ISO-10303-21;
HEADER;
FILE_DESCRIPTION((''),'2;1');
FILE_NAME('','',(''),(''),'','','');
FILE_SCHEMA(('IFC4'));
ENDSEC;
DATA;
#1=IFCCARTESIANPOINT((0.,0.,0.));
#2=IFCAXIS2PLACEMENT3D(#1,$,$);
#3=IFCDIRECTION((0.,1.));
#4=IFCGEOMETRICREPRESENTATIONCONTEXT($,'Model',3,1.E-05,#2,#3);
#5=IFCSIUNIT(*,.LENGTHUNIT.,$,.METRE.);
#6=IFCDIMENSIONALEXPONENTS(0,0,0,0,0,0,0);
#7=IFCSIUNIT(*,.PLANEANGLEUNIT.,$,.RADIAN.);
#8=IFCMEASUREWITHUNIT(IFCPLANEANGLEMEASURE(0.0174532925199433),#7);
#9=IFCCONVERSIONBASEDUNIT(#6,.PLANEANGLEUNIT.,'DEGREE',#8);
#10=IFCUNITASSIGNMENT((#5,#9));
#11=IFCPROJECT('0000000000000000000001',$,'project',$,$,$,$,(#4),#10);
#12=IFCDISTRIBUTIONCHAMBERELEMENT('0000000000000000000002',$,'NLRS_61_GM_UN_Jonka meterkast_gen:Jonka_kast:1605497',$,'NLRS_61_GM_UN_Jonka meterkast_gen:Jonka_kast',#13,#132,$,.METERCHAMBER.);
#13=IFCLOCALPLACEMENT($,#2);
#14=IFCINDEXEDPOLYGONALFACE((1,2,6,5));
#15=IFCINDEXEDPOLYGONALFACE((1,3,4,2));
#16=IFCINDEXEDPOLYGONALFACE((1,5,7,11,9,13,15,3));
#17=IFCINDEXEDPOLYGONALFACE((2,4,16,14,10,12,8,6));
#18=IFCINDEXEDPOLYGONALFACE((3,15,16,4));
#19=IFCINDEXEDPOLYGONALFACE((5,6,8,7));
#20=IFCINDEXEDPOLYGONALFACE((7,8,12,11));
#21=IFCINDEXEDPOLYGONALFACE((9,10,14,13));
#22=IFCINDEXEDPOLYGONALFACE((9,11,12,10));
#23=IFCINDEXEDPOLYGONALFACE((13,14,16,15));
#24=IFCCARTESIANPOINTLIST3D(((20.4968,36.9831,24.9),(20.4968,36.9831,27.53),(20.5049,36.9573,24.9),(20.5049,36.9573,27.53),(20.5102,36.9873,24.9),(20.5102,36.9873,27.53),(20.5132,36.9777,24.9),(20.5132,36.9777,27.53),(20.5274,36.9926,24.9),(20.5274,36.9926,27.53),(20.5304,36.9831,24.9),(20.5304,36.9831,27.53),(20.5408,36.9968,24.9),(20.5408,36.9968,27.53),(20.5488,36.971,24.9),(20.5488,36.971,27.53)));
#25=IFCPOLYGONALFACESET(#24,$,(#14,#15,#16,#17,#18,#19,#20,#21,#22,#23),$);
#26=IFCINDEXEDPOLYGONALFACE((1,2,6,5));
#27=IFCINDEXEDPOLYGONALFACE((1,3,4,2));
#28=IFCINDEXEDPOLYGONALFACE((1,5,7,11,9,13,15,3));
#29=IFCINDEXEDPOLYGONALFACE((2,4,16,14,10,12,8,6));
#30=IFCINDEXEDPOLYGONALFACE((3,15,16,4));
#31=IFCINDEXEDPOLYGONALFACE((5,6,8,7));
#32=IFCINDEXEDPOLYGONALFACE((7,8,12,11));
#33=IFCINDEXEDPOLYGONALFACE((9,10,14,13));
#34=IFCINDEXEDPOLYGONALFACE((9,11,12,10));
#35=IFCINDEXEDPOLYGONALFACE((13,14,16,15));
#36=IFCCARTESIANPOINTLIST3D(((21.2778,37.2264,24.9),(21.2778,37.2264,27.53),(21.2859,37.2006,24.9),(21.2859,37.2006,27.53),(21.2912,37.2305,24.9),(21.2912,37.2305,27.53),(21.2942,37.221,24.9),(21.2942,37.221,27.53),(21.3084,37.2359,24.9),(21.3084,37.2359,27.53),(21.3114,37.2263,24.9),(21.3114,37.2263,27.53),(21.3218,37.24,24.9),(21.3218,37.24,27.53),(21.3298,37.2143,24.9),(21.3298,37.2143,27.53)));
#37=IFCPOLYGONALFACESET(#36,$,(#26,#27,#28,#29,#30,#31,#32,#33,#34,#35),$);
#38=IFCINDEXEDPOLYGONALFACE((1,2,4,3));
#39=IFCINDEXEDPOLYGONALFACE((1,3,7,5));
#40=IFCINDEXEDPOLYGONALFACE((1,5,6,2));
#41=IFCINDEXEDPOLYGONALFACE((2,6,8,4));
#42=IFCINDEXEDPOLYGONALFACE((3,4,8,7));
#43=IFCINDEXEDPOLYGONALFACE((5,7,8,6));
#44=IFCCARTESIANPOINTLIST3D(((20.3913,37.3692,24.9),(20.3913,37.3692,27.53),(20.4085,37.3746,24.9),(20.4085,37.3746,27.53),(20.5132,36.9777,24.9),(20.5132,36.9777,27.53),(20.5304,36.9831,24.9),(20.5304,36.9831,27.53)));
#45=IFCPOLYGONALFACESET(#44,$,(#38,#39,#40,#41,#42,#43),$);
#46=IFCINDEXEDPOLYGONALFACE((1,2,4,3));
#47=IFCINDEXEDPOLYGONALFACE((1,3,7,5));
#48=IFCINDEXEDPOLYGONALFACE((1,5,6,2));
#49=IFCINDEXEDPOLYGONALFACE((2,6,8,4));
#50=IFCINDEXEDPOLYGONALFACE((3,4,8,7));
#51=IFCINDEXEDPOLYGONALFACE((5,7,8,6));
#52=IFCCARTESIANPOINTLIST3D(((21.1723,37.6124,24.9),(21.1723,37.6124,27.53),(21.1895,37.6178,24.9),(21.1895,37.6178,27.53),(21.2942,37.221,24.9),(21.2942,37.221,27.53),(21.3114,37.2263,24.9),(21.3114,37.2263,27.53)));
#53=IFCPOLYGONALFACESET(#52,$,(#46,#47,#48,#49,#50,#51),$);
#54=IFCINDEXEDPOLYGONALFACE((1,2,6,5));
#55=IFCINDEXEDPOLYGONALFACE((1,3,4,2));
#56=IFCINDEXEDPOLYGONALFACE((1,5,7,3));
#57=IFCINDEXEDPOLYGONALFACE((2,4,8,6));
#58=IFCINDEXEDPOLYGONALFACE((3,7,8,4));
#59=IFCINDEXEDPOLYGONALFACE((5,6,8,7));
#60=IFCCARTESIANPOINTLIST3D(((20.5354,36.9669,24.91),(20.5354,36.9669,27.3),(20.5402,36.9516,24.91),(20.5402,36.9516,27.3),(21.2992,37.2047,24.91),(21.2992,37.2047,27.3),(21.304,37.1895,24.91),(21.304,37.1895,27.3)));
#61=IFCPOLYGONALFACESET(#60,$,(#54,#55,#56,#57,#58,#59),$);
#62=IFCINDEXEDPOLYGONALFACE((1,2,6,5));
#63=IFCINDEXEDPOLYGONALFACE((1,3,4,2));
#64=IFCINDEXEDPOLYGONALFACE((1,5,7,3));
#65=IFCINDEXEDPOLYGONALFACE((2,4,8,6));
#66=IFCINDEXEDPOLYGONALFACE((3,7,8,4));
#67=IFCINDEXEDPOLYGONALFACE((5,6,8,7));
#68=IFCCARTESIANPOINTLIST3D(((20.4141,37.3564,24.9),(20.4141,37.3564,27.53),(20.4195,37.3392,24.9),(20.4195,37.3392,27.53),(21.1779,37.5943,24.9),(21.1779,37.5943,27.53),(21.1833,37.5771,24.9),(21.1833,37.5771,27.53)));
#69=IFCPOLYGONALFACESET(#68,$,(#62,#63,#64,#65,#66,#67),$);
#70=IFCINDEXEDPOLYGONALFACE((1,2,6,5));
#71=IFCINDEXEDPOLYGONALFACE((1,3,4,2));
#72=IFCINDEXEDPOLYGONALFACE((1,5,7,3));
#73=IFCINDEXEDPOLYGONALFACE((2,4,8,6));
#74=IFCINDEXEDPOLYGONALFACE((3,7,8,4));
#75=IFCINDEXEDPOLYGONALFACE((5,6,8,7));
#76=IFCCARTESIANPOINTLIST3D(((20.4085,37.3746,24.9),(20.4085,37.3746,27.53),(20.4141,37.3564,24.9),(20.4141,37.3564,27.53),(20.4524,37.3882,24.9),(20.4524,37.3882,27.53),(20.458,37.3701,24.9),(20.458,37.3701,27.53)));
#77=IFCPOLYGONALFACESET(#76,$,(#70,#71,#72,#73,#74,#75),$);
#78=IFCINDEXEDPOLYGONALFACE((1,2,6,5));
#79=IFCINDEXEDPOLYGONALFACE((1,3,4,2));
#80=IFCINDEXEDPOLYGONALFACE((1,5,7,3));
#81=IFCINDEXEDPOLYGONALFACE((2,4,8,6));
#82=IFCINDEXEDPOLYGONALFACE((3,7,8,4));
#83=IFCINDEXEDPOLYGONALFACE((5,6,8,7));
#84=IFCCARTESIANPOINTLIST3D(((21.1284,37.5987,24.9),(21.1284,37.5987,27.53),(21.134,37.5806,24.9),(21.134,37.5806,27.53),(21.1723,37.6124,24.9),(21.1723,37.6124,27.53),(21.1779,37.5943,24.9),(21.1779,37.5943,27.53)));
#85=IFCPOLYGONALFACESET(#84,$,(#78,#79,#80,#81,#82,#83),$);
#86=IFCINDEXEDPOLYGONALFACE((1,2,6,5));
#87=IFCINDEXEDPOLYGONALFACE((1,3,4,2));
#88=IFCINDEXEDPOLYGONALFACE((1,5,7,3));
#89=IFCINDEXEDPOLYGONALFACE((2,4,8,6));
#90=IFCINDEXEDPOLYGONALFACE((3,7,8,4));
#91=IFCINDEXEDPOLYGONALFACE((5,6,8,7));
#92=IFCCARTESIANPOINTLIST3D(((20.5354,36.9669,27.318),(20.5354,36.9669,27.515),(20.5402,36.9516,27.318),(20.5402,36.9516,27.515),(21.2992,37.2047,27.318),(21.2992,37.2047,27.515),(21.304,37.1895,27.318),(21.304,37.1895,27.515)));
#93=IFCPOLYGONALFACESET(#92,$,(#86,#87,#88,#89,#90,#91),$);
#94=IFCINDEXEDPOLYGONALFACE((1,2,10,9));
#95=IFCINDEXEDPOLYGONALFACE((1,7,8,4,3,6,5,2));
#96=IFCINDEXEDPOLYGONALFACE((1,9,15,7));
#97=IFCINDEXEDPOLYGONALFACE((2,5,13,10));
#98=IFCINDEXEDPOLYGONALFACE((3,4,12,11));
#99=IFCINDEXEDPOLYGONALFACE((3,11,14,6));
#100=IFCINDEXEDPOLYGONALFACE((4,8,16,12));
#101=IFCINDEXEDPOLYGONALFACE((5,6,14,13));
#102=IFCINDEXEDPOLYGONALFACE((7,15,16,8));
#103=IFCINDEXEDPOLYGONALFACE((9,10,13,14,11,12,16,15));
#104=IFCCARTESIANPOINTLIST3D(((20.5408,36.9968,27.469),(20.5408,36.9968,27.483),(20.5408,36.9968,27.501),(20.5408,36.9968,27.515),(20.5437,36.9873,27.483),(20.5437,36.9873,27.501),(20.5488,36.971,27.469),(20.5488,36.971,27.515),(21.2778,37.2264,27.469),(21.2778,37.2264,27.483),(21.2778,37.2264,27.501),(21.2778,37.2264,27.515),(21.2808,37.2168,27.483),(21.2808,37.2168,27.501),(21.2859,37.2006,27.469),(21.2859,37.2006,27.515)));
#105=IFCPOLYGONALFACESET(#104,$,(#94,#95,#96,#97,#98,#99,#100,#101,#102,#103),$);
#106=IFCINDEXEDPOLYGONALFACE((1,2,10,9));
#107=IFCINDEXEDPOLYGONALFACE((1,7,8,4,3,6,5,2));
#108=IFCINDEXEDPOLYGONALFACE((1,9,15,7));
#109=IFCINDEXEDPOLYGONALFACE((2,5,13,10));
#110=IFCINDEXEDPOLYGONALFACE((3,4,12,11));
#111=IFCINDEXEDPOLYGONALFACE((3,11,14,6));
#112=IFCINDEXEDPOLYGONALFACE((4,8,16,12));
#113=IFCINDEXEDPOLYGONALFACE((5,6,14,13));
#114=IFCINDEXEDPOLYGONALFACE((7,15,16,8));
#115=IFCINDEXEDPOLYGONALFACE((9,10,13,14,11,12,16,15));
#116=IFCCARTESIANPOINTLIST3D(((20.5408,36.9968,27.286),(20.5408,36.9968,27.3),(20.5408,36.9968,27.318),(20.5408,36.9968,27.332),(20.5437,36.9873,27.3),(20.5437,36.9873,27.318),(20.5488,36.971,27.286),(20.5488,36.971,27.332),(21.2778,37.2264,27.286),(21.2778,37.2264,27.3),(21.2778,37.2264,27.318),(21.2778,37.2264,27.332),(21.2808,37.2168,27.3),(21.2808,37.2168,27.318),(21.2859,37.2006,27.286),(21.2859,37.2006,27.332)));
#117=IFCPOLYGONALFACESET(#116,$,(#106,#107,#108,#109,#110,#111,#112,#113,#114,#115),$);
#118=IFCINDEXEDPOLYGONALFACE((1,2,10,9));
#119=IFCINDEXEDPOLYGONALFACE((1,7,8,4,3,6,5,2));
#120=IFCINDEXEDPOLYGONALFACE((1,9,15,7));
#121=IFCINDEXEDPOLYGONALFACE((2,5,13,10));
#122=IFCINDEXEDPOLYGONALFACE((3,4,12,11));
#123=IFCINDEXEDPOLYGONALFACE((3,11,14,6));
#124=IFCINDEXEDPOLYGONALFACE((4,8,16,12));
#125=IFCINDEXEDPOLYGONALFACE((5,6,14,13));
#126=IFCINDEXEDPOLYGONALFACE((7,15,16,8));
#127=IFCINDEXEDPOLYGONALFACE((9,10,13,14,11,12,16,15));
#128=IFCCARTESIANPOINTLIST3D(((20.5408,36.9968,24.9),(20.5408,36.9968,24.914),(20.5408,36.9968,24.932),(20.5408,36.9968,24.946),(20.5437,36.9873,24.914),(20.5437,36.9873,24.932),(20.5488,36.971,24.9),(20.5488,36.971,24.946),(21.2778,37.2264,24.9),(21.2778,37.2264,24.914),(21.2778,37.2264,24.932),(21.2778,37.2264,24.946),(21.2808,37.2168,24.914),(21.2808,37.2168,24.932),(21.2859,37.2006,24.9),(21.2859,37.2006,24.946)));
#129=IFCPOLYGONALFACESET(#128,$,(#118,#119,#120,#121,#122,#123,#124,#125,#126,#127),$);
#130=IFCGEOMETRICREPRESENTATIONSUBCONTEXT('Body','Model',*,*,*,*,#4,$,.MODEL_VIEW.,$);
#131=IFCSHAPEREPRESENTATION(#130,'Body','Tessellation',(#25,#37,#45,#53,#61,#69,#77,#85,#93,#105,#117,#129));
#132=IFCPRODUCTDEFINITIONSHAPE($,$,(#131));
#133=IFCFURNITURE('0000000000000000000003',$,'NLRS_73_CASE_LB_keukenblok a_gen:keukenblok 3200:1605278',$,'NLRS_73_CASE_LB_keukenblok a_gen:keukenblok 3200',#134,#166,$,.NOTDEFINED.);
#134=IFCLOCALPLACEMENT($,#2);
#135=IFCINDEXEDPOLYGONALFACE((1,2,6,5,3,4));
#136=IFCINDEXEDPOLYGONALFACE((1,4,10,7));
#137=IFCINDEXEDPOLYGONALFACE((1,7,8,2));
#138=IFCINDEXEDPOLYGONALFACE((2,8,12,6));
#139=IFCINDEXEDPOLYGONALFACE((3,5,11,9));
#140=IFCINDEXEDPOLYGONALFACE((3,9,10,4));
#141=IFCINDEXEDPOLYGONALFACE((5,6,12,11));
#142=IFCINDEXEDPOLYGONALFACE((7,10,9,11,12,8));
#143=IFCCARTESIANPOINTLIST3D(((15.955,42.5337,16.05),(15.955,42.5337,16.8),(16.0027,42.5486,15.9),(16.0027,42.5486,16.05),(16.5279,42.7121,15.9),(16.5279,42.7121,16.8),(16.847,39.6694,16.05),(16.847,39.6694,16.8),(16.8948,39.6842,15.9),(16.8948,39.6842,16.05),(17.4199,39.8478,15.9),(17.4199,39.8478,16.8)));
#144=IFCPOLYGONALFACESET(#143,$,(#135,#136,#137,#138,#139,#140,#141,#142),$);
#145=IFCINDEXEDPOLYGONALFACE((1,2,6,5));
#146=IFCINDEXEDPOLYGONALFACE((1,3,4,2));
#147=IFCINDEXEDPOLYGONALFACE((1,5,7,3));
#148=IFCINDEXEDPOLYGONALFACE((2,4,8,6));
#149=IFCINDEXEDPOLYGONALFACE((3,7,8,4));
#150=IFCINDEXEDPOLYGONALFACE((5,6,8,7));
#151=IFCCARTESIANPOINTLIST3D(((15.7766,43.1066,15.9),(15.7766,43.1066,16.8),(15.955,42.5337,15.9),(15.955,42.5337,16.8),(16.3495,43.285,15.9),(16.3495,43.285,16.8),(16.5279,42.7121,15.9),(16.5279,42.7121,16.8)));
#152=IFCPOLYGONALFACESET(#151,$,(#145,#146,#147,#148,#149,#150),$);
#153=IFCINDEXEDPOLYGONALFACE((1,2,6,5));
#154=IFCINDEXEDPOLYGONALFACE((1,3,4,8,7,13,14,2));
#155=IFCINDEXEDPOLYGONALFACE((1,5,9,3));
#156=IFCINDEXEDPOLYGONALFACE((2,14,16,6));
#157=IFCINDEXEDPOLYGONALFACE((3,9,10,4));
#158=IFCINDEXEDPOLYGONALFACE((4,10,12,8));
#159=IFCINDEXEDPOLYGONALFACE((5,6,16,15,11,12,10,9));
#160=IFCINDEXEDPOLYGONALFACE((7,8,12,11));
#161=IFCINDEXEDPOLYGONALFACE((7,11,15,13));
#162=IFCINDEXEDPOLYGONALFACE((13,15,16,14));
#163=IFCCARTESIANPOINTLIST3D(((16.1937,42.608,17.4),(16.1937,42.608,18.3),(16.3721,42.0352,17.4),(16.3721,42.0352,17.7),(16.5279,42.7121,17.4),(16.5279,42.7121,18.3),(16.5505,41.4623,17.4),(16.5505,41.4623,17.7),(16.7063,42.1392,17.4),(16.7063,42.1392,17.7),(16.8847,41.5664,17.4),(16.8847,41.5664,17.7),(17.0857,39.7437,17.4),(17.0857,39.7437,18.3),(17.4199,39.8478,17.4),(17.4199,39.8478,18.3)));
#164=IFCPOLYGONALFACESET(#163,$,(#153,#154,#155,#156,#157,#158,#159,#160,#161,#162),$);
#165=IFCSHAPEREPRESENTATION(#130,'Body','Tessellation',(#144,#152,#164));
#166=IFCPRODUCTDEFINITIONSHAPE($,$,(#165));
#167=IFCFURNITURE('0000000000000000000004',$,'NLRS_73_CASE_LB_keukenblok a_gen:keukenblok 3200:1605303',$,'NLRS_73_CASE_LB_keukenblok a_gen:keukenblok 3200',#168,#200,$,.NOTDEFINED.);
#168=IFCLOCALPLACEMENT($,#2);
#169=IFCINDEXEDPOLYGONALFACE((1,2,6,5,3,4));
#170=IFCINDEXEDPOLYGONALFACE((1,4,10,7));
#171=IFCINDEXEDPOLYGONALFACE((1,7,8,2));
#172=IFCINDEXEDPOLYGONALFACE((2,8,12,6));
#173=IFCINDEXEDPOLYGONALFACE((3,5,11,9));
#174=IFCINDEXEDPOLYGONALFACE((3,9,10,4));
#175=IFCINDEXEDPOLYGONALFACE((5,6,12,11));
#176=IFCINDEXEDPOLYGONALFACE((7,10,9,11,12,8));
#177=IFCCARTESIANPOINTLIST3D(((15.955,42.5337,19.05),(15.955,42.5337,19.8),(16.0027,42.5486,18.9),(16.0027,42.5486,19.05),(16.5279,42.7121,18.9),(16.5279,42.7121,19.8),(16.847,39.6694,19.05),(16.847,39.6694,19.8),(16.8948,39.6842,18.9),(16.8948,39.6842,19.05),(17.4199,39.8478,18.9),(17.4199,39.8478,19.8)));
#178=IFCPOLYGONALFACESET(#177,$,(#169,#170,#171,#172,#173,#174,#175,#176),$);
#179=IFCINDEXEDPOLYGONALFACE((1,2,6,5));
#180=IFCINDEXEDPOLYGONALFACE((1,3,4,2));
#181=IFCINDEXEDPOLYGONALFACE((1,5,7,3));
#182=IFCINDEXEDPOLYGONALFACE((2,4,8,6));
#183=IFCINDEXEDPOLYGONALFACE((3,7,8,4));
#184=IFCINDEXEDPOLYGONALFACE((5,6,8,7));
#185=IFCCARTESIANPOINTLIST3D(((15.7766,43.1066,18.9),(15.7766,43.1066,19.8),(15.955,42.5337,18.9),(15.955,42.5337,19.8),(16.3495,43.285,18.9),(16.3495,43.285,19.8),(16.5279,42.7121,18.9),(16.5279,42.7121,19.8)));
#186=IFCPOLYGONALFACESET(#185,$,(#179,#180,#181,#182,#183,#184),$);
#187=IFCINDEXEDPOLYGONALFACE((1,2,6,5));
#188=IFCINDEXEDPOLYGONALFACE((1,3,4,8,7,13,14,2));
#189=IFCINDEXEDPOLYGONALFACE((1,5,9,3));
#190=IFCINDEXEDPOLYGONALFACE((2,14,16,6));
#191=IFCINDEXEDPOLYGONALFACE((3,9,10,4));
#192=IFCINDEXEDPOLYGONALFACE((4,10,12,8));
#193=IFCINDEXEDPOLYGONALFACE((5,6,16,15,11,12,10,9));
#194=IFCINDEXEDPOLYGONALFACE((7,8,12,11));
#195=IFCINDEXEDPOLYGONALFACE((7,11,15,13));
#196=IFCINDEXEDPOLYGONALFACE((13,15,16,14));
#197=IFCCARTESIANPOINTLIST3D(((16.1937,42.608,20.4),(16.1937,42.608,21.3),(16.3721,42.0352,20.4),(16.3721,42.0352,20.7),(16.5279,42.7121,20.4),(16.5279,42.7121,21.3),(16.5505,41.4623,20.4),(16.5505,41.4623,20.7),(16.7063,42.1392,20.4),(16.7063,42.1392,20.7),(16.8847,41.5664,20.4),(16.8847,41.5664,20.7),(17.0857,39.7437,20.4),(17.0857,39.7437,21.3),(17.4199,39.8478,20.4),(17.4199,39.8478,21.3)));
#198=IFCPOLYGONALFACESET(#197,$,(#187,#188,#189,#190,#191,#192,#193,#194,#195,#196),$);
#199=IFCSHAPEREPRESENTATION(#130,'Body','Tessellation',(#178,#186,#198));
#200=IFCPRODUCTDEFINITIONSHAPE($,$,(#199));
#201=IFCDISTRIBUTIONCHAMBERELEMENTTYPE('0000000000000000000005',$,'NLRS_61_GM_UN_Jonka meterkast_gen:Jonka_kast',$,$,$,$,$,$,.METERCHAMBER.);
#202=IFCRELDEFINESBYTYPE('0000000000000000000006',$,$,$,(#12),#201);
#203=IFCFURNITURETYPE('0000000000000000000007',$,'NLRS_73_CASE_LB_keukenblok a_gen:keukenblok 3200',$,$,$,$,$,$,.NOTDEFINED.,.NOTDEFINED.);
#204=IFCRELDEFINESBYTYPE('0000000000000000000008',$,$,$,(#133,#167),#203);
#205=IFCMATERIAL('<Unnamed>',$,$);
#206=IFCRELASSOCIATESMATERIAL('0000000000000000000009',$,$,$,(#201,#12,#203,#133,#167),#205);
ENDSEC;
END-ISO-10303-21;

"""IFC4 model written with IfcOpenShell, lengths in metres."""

from ifc_helpers import new_model, entity, si_unit, converted_unit, direction, frame, origin, place, context, subcontext, project, indexed_curve, outline, extrude, source, transform, mapped, material, type_object, type_shapes, element, save


model = new_model("IFC4")

# Units and contexts
model_context = context("Model", 3, precision=1e-05, world=origin(), true_north=direction((0.0, 1.0)))
body_context = subcontext(model_context, "Body", "Model", "MODEL_VIEW")
ifc_project = project(units=[si_unit("LENGTHUNIT", "METRE"), converted_unit("PLANEANGLEUNIT", "DEGREE", entity("IfcPlaneAngleMeasure", 0.0174532925199433), si_unit("PLANEANGLEUNIT", "RADIAN"), dimensions=[0, 0, 0, 0, 0, 0, 0])], contexts=[model_context])

# Distribution chamber element
ifc_material = material(Name="<Unnamed>")
distribution_chamber_element_type = type_object("IfcDistributionChamberElementType", Name="NLRS_61_GM_UN_Jonka meterkast_gen:Jonka_kast", PredefinedType="METERCHAMBER", material=ifc_material)
shared_shape_1 = source(origin(), body_context, "Body", "SweptSolid", [
    extrude(outline(indexed_curve([(-0.0093, -0.023), (0.0178, -0.023), (0.0178, 0.023), (-0.0093, 0.023), (-0.0093, 0.009), (0.0007, 0.009), (0.0007, -0.009), (-0.0093, -0.009), (-0.0093, -0.023)], self_intersect=False)), frame((-0.409, -0.4092, 0.0), z_axis=(0.0, 0.0, 1.0), x_axis=(0.0, -1.0, 0.0)), (0.0, 0.0, 1.0), 2.63),
    extrude(outline(indexed_curve([(-0.0093, -0.023), (0.0178, -0.023), (0.0178, 0.023), (-0.0093, 0.023), (-0.0093, 0.009), (0.0007, 0.009), (0.0007, -0.009), (-0.0093, -0.009), (-0.0093, -0.023)], self_intersect=False)), frame((0.409, -0.4092, 0.0), z_axis=(0.0, 0.0, 1.0), x_axis=(0.0, -1.0, 0.0)), (0.0, 0.0, 1.0), 2.63),
    extrude(outline(indexed_curve([(-0.205, -0.009), (0.205, -0.009), (0.205, 0.009), (-0.205, 0.009), (-0.205, -0.009)], self_intersect=False)), frame((-0.409, -0.205, 0.0), z_axis=(0.0, 0.0, 1.0), x_axis=(0.0, -1.0, 0.0)), (0.0, 0.0, 1.0), 2.63),
    extrude(outline(indexed_curve([(-0.205, -0.009), (0.205, -0.009), (0.205, 0.009), (-0.205, 0.009), (-0.205, -0.009)], self_intersect=False)), frame((0.409, -0.205, 0.0), z_axis=(0.0, 0.0, 1.0), x_axis=(0.0, -1.0, 0.0)), (0.0, 0.0, 1.0), 2.63),
    extrude(outline(indexed_curve([(-0.4, -0.008), (0.4, -0.008), (0.4, 0.008), (-0.4, 0.008), (-0.4, -0.008)], self_intersect=False)), frame((0.0, -0.435, 0.01), z_axis=(0.0, 0.0, 1.0), x_axis=(-1.0, 0.0, 0.0)), (0.0, 0.0, 1.0), 2.39),
    extrude(outline(indexed_curve([(-0.4, -0.009), (0.4, -0.009), (0.4, 0.009), (-0.4, 0.009), (-0.4, -0.009)], self_intersect=False)), frame((0.0, -0.028, 0.0), z_axis=(0.0, 0.0, 1.0), x_axis=(-1.0, 0.0, 0.0)), (0.0, 0.0, 1.0), 2.63),
    extrude(outline(indexed_curve([(-0.023, -0.0095), (0.023, -0.0095), (0.023, 0.0095), (-0.023, 0.0095), (-0.023, -0.0095)], self_intersect=False)), frame((-0.377, -0.0095, 0.0), z_axis=(0.0, 0.0, 1.0), x_axis=(-1.0, 0.0, 0.0)), (0.0, 0.0, 1.0), 2.63),
    extrude(outline(indexed_curve([(-0.023, -0.0095), (0.023, -0.0095), (0.023, 0.0095), (-0.023, 0.0095), (-0.023, -0.0095)], self_intersect=False)), frame((0.377, -0.0095, 0.0), z_axis=(0.0, 0.0, 1.0), x_axis=(-1.0, 0.0, 0.0)), (0.0, 0.0, 1.0), 2.63),
    extrude(outline(indexed_curve([(-0.4, -0.008), (0.4, -0.008), (0.4, 0.008), (-0.4, 0.008), (-0.4, -0.008)], self_intersect=False)), frame((0.0, -0.435, 2.418), z_axis=(0.0, 0.0, 1.0), x_axis=(-1.0, 0.0, 0.0)), (0.0, 0.0, 1.0), 0.197),
    extrude(outline(indexed_curve([(-0.023, -0.0178), (0.023, -0.0178), (0.023, 0.0093), (0.009, 0.0093), (0.009, -0.0007), (-0.009, -0.0007), (-0.009, 0.0093), (-0.023, 0.0093), (-0.023, -0.0178)], self_intersect=False)), frame((-0.386, -0.4092, 2.592), z_axis=(1.0, 0.0, 0.0), x_axis=(0.0, 0.0, -1.0)), (0.0, 0.0, 1.0), 0.772),
    extrude(outline(indexed_curve([(-0.023, -0.0178), (0.023, -0.0178), (0.023, 0.0093), (0.009, 0.0093), (0.009, -0.0007), (-0.009, -0.0007), (-0.009, 0.0093), (-0.023, 0.0093), (-0.023, -0.0178)], self_intersect=False)), frame((-0.386, -0.4092, 2.409), z_axis=(1.0, 0.0, 0.0), x_axis=(0.0, 0.0, -1.0)), (0.0, 0.0, 1.0), 0.772),
    extrude(outline(indexed_curve([(-0.023, -0.0178), (0.023, -0.0178), (0.023, 0.0093), (0.009, 0.0093), (0.009, -0.0007), (-0.009, -0.0007), (-0.009, 0.0093), (-0.023, 0.0093), (-0.023, -0.0178)], self_intersect=False)), frame((-0.386, -0.4092, 0.023), z_axis=(1.0, 0.0, 0.0), x_axis=(0.0, 0.0, -1.0)), (0.0, 0.0, 1.0), 0.772),
])
type_shapes(distribution_chamber_element_type, [shared_shape_1])
placement_1 = place(None, frame((13.1348, 11.9886, 0.0), z_axis=(0.0, 0.0, 1.0), x_axis=(0.954771, 0.297342, 0.0)))
placement_2 = place(placement_1, origin())
placement_3 = place(placement_2, frame((0.0, 0.0, 15.9)))
placement_4 = place(placement_2, frame((0.0, 0.0, 18.9)))
placement_5 = place(placement_2, frame((0.0, 0.0, 24.9)))
placement_6 = place(placement_5, origin())
distribution_chamber_element_1_placement = place(placement_6, frame((14.893, 22.075, 0.0)))
element("IfcDistributionChamberElement", 1, at=distribution_chamber_element_1_placement, type_object=distribution_chamber_element_type, material=ifc_material, Name="NLRS_61_GM_UN_Jonka meterkast_gen:Jonka_kast:1605497", ObjectType="NLRS_61_GM_UN_Jonka meterkast_gen:Jonka_kast", PredefinedType="METERCHAMBER", context=body_context, shape_type="MappedRepresentation", body=[
    mapped(shared_shape_1, transform((0.0, 0.0, 0.0), scale=1.0)),
])

# Furniture
furniture_type = type_object("IfcFurnitureType", Name="NLRS_73_CASE_LB_keukenblok a_gen:keukenblok 3200", AssemblyPlace="NOTDEFINED", PredefinedType="NOTDEFINED", material=ifc_material)
shared_shape_2 = source(origin(), body_context, "Body", "SweptSolid", [
    extrude(outline(indexed_curve([(-0.35, 0.1667), (-0.35, -0.3833), (0.55, -0.3833), (0.55, 0.2167), (-0.2, 0.2167), (-0.2, 0.1667), (-0.35, 0.1667)], self_intersect=False)), frame((0.0, 0.3833, 0.35), z_axis=(-1.0, 0.0, 0.0), x_axis=(0.0, 0.0, 1.0)), (0.0, 0.0, -1.0), 3.0),
    extrude(outline(indexed_curve([(-0.3, -0.3), (0.3, -0.3), (0.3, 0.3), (-0.3, 0.3), (-0.3, -0.3)], self_intersect=False)), frame((3.3, 0.3, 0.0), z_axis=(0.0, 0.0, 1.0), x_axis=(0.0, 1.0, 0.0)), (0.0, 0.0, 1.0), 0.9),
    extrude(outline(indexed_curve([(-1.2, -0.3), (-0.6, -0.3), (-0.6, 0.0), (0.0, 0.0), (0.0, -0.3), (1.8, -0.3), (1.8, 0.6), (-1.2, 0.6), (-1.2, -0.3)], self_intersect=False)), frame((1.8, 0.0, 1.8), z_axis=(0.0, 1.0, 0.0), x_axis=(-1.0, 0.0, 0.0)), (0.0, 0.0, 1.0), 0.35),
])
type_shapes(furniture_type, [shared_shape_2])
placement_7 = place(placement_3, origin())
furniture_1_placement = place(placement_7, frame((12.375, 25.325, 0.0), z_axis=(0.0, 0.0, 1.0), x_axis=(0.0, 1.0, 0.0)))
element("IfcFurniture", 2, at=furniture_1_placement, type_object=furniture_type, material=ifc_material, Name="NLRS_73_CASE_LB_keukenblok a_gen:keukenblok 3200:1605278", ObjectType="NLRS_73_CASE_LB_keukenblok a_gen:keukenblok 3200", PredefinedType="NOTDEFINED", context=body_context, shape_type="MappedRepresentation", body=[
    mapped(shared_shape_2, transform((0.0, 0.0, 0.0), scale=1.0)),
])
placement_8 = place(placement_4, origin())
furniture_2_placement = place(placement_8, frame((12.375, 25.325, 0.0), z_axis=(0.0, 0.0, 1.0), x_axis=(0.0, 1.0, 0.0)))
element("IfcFurniture", 3, at=furniture_2_placement, type_object=furniture_type, material=ifc_material, Name="NLRS_73_CASE_LB_keukenblok a_gen:keukenblok 3200:1605303", ObjectType="NLRS_73_CASE_LB_keukenblok a_gen:keukenblok 3200", PredefinedType="NOTDEFINED", context=body_context, shape_type="MappedRepresentation", body=[
    mapped(shared_shape_2, transform((0.0, 0.0, 0.0), scale=1.0)),
])

save(model, "model.ifc")
